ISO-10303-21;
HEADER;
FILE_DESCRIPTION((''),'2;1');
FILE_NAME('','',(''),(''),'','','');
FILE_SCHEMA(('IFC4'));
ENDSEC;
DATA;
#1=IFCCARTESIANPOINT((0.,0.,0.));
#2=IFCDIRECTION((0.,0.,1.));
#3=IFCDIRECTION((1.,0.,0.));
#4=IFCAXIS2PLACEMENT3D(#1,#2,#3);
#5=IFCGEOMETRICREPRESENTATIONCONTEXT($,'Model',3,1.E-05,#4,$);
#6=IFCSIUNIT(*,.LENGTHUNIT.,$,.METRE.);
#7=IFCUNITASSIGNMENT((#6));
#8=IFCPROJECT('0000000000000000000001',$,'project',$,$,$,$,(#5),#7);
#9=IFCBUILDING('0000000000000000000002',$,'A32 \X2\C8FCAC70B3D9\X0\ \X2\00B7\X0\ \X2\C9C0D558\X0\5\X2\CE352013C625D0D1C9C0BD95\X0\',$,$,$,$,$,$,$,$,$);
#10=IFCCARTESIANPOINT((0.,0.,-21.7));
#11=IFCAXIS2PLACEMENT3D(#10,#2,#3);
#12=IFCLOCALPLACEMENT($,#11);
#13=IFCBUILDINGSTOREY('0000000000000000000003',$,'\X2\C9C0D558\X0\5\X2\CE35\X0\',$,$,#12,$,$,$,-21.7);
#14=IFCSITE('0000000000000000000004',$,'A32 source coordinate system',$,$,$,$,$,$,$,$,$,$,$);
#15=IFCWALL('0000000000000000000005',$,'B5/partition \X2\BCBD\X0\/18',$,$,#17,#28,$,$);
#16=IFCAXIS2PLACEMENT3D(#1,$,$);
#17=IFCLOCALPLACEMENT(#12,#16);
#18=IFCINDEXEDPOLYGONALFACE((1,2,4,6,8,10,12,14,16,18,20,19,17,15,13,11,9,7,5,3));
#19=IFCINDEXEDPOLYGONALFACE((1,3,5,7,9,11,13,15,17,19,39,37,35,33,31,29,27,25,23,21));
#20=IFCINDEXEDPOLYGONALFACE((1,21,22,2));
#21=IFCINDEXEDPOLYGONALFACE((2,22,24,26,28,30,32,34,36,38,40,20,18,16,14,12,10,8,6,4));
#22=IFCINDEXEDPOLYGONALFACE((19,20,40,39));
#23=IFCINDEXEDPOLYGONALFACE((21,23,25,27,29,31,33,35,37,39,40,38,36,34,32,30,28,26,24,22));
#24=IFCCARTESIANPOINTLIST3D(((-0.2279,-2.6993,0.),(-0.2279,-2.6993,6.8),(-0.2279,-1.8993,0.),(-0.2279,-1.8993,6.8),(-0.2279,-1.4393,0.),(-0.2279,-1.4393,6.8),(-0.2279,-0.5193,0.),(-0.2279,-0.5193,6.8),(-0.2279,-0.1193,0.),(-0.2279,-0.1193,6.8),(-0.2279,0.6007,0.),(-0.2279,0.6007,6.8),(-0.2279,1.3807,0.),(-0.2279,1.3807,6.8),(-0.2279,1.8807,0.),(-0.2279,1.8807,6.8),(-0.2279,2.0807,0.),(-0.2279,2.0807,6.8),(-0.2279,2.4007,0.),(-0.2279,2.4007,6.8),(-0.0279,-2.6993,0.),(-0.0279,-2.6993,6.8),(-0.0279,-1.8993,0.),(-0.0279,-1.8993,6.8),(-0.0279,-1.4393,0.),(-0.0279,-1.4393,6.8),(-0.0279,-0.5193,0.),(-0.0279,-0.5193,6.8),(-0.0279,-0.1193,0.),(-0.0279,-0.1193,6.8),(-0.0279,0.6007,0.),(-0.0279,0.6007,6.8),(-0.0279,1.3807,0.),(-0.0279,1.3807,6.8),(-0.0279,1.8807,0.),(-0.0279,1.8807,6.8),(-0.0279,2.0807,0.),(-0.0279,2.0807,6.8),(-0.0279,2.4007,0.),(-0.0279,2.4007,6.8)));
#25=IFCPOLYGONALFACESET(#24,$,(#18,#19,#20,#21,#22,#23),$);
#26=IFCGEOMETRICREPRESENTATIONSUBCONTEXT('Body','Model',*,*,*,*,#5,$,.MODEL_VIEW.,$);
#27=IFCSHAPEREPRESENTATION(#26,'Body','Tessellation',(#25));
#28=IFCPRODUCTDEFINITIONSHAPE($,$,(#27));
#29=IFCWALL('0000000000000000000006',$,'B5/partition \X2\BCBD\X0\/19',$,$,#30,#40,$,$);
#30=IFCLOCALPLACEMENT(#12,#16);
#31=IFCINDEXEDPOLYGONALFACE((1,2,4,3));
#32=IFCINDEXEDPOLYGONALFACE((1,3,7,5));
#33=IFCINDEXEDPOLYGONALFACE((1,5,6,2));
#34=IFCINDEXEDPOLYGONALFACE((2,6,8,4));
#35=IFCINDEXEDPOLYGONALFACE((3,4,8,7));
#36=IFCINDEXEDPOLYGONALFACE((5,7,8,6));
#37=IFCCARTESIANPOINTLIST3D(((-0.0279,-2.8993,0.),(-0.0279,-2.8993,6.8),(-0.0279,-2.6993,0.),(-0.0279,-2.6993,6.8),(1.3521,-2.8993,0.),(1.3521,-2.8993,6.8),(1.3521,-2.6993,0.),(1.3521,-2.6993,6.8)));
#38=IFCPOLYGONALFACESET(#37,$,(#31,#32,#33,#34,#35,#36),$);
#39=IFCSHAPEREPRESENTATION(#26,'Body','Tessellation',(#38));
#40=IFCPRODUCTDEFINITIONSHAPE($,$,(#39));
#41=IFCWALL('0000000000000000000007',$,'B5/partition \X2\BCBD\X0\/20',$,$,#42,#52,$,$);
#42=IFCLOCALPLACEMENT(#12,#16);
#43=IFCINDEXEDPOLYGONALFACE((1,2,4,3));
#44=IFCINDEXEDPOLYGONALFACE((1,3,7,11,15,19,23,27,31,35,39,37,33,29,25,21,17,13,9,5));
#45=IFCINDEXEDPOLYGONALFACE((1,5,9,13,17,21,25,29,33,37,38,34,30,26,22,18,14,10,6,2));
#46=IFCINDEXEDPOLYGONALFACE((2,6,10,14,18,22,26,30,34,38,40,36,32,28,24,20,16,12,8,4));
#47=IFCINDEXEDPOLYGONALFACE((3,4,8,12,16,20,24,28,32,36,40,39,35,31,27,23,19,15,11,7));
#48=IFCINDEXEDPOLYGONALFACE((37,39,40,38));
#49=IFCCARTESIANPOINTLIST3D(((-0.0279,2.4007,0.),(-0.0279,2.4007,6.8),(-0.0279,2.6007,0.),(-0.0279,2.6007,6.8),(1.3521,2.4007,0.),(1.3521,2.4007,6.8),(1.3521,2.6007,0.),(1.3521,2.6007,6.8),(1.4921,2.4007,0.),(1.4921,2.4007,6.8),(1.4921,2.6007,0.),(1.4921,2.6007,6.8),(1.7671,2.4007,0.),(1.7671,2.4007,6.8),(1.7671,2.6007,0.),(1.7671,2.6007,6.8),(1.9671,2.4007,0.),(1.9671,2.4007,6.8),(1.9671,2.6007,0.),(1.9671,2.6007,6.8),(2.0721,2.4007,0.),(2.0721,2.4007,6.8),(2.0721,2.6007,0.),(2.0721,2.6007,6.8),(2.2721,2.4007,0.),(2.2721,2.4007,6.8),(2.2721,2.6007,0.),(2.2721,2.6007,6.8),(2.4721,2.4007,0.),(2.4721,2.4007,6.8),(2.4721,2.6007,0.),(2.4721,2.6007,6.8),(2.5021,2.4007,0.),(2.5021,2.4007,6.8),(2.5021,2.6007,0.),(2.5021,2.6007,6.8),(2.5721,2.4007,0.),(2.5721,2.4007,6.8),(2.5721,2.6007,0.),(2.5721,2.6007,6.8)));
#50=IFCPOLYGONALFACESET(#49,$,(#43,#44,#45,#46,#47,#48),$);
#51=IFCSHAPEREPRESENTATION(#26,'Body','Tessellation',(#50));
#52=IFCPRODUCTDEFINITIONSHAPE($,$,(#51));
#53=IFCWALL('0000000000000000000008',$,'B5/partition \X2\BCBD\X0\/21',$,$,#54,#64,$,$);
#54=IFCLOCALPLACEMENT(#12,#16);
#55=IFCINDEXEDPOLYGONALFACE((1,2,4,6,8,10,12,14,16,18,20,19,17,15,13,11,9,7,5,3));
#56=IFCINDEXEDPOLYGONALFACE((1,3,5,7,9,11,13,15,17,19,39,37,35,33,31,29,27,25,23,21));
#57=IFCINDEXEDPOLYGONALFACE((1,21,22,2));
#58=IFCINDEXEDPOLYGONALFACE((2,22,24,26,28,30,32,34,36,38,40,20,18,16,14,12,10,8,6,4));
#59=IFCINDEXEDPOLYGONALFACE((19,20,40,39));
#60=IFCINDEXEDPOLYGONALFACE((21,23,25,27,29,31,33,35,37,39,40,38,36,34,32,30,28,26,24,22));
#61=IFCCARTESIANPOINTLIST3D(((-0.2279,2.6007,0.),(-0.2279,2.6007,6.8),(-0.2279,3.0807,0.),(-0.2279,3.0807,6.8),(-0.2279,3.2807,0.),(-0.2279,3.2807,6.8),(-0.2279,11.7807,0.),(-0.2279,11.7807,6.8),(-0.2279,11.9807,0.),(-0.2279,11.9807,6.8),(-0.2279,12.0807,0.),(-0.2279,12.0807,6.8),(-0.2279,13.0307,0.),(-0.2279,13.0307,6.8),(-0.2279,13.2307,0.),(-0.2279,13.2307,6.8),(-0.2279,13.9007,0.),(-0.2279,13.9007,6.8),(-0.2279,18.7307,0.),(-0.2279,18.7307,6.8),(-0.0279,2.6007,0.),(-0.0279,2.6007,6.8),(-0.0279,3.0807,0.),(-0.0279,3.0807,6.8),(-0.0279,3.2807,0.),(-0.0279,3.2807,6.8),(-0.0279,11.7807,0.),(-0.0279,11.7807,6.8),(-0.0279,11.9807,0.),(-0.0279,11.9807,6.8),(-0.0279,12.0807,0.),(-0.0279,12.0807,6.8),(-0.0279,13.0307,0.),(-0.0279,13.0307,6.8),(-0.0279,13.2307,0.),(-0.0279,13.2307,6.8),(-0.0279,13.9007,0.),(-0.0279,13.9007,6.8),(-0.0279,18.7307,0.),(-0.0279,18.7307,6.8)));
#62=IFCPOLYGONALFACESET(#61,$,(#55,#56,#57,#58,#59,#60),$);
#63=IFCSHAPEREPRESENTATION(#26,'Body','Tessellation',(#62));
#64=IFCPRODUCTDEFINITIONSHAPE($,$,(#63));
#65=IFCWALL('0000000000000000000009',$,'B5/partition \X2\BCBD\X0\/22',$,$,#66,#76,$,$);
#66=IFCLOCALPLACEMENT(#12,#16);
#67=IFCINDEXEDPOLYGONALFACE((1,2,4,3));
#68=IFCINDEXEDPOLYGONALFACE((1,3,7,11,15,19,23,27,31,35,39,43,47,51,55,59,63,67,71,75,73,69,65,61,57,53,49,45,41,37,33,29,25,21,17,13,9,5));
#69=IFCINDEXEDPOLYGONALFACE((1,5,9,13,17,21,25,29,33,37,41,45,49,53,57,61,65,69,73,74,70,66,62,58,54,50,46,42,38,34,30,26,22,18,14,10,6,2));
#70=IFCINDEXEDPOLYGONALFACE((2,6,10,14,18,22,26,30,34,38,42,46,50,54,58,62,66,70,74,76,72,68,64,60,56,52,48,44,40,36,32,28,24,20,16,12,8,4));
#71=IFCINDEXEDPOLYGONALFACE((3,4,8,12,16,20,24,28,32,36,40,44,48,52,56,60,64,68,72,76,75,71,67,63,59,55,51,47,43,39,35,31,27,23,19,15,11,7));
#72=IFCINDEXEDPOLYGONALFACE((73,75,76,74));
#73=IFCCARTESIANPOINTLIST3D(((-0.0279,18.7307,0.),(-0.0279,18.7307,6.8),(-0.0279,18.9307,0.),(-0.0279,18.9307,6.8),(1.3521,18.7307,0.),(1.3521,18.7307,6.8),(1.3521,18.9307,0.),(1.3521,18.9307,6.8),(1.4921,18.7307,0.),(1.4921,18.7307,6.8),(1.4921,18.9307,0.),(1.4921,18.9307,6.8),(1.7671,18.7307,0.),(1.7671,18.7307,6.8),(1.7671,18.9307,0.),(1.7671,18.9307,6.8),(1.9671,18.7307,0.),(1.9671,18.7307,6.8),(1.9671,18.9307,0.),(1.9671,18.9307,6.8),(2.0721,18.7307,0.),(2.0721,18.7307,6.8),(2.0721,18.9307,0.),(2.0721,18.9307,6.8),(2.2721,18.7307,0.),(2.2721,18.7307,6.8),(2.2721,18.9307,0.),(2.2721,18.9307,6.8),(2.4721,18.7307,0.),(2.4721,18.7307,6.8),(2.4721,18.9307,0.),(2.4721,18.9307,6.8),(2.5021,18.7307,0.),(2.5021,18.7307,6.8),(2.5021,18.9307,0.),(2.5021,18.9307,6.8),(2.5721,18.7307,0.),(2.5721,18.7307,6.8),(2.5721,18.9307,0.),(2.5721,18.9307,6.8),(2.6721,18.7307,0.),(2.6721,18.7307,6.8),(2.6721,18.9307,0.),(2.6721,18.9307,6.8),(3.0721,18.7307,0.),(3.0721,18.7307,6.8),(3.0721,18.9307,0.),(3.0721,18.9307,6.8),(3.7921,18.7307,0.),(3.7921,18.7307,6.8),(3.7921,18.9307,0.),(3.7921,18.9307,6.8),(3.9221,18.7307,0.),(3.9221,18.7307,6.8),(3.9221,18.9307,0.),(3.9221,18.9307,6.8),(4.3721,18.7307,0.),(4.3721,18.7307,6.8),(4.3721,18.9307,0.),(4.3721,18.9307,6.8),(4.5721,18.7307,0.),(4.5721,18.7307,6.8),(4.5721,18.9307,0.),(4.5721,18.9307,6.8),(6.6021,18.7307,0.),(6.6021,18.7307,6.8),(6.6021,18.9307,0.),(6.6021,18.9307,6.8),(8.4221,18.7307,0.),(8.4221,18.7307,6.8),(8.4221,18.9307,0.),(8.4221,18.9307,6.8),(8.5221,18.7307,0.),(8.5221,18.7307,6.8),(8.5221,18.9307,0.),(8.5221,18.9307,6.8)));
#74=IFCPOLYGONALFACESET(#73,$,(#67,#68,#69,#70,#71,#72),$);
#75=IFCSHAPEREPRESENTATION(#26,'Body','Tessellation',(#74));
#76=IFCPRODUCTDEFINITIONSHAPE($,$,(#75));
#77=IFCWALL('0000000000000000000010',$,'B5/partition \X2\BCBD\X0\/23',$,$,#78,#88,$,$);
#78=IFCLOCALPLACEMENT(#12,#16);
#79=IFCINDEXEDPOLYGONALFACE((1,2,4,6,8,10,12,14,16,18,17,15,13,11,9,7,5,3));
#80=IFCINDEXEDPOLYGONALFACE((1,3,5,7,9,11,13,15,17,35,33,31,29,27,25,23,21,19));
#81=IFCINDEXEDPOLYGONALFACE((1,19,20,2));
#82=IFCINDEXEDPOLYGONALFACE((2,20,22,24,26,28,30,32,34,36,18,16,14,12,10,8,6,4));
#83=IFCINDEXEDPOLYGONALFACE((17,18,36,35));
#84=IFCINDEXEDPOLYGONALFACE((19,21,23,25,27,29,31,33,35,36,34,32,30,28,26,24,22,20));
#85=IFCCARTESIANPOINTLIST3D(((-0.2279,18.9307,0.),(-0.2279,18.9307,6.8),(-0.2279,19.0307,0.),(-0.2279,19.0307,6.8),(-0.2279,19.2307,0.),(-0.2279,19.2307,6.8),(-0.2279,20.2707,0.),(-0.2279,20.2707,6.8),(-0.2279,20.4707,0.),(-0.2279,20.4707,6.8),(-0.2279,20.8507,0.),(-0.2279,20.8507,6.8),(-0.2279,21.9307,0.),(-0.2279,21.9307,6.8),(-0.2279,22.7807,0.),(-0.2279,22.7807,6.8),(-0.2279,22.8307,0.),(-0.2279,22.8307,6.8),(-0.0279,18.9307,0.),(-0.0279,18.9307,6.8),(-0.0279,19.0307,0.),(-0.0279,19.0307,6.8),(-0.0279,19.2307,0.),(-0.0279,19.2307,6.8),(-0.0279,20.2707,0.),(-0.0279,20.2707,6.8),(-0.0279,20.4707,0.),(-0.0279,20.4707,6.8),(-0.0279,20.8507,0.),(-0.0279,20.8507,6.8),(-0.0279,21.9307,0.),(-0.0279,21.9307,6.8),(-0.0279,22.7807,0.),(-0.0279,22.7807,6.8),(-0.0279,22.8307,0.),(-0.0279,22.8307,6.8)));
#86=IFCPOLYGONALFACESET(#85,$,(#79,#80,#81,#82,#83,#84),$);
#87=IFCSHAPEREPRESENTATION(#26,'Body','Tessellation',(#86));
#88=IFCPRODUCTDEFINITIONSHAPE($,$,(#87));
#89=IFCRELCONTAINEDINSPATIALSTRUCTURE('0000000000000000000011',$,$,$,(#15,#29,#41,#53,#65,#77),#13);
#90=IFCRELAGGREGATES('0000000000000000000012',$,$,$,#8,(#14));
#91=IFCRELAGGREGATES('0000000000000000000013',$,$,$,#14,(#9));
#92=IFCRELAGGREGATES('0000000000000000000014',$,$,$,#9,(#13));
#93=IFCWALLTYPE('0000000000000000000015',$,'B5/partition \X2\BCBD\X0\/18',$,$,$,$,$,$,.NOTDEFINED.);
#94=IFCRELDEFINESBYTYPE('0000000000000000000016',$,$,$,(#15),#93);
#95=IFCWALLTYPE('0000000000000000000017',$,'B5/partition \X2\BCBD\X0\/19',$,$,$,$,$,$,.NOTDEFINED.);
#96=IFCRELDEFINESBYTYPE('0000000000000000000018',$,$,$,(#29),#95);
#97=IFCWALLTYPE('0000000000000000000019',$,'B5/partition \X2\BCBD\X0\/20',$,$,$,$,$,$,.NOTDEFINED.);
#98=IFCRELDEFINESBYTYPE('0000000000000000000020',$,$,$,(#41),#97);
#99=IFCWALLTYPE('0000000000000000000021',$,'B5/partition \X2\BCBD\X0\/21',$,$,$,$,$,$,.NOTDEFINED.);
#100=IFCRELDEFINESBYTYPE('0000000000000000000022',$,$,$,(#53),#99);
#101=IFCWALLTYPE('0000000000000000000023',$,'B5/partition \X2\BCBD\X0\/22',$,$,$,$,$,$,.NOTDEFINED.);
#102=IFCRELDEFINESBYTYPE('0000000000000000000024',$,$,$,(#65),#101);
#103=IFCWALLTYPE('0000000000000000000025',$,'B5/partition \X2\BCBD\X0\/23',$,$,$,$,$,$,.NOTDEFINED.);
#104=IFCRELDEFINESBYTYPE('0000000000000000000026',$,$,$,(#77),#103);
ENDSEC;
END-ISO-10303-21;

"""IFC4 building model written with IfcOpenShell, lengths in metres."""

from ifc_helpers import new_model, si_unit, frame, origin, origin_with_axes, place, context, subcontext, project, spatial, polyline, outline, extrude, source, transform, mapped, type_object, type_shapes, element, save


model = new_model("IFC4")

# Units and contexts
model_context = context("Model", 3, precision=1e-05, world=origin_with_axes())
body_context = subcontext(model_context, "Body", "Model", "MODEL_VIEW")
ifc_project = project(units=[si_unit("LENGTHUNIT", "METRE")], contexts=[model_context])

# Site, building, storey
site = spatial("IfcSite", under=ifc_project, Name="A32 source coordinate system")
building = spatial("IfcBuilding", under=site, Name="A32 주거동 · 지하5층–옥탑지붕")
storey_placement = place(None, frame((0.0, 0.0, -21.7), z_axis=(0.0, 0.0, 1.0), x_axis=(1.0, 0.0, 0.0)))
storey = spatial("IfcBuildingStorey", under=building, at=storey_placement, Name="지하5층", Elevation=-21.7)

# Walls
wall_type_1 = type_object("IfcWallType", Name="B5/partition 벽/18", PredefinedType="NOTDEFINED")
shared_shape_1 = source(origin(), body_context, "Body", "SweptSolid", [
    extrude(outline(polyline([(-0.2279, 1.8807), (-0.2279, 2.0807), (-0.2279, 2.4007), (-0.0279, 2.4007), (-0.0279, 2.0807), (-0.0279, 1.8807), (-0.0279, 1.3807), (-0.0279, 0.6007), (-0.0279, -0.1193), (-0.0279, -0.5193), (-0.0279, -1.4393), (-0.0279, -1.8993), (-0.0279, -2.6993), (-0.2279, -2.6993), (-0.2279, -1.8993), (-0.2279, -1.4393), (-0.2279, -0.5193), (-0.2279, -0.1193), (-0.2279, 0.6007), (-0.2279, 1.3807), (-0.2279, 1.8807)])), origin(), (0.0, 0.0, 1.0), 6.8),
])
type_shapes(wall_type_1, [shared_shape_1])
wall_1_placement = place(storey_placement, origin_with_axes())
element("IfcWall", 1, at=wall_1_placement, inside=storey, type_object=wall_type_1, Name="B5/partition 벽/18", context=body_context, shape_type="MappedRepresentation", body=[
    mapped(shared_shape_1, transform((0.0, 0.0, 0.0), scale=1.0)),
])
wall_type_2 = type_object("IfcWallType", Name="B5/partition 벽/19", PredefinedType="NOTDEFINED")
shared_shape_2 = source(origin(), body_context, "Body", "SweptSolid", [
    extrude(outline(polyline([(1.3521, -2.6993), (1.3521, -2.8993), (-0.0279, -2.8993), (-0.0279, -2.6993), (1.3521, -2.6993)])), origin(), (0.0, 0.0, 1.0), 6.8),
])
type_shapes(wall_type_2, [shared_shape_2])
wall_2_placement = place(storey_placement, origin_with_axes())
element("IfcWall", 2, at=wall_2_placement, inside=storey, type_object=wall_type_2, Name="B5/partition 벽/19", context=body_context, shape_type="MappedRepresentation", body=[
    mapped(shared_shape_2, transform((0.0, 0.0, 0.0), scale=1.0)),
])
wall_type_3 = type_object("IfcWallType", Name="B5/partition 벽/20", PredefinedType="NOTDEFINED")
shared_shape_3 = source(origin(), body_context, "Body", "SweptSolid", [
    extrude(outline(polyline([(-0.0279, 2.6007), (1.3521, 2.6007), (1.4921, 2.6007), (1.7671, 2.6007), (1.9671, 2.6007), (2.0721, 2.6007), (2.2721, 2.6007), (2.4721, 2.6007), (2.5021, 2.6007), (2.5721, 2.6007), (2.5721, 2.4007), (2.5021, 2.4007), (2.4721, 2.4007), (2.2721, 2.4007), (2.0721, 2.4007), (1.9671, 2.4007), (1.7671, 2.4007), (1.4921, 2.4007), (1.3521, 2.4007), (-0.0279, 2.4007), (-0.0279, 2.6007)])), origin(), (0.0, 0.0, 1.0), 6.8),
])
type_shapes(wall_type_3, [shared_shape_3])
wall_3_placement = place(storey_placement, origin_with_axes())
element("IfcWall", 3, at=wall_3_placement, inside=storey, type_object=wall_type_3, Name="B5/partition 벽/20", context=body_context, shape_type="MappedRepresentation", body=[
    mapped(shared_shape_3, transform((0.0, 0.0, 0.0), scale=1.0)),
])
wall_type_4 = type_object("IfcWallType", Name="B5/partition 벽/21", PredefinedType="NOTDEFINED")
shared_shape_4 = source(origin(), body_context, "Body", "SweptSolid", [
    extrude(outline(polyline([(-0.2279, 2.6007), (-0.2279, 3.0807), (-0.2279, 3.2807), (-0.2279, 11.7807), (-0.2279, 11.9807), (-0.2279, 12.0807), (-0.2279, 13.0307), (-0.2279, 13.2307), (-0.2279, 13.9007), (-0.2279, 18.7307), (-0.0279, 18.7307), (-0.0279, 13.9007), (-0.0279, 13.2307), (-0.0279, 13.0307), (-0.0279, 12.0807), (-0.0279, 11.9807), (-0.0279, 11.7807), (-0.0279, 3.2807), (-0.0279, 3.0807), (-0.0279, 2.6007), (-0.2279, 2.6007)])), origin(), (0.0, 0.0, 1.0), 6.8),
])
type_shapes(wall_type_4, [shared_shape_4])
wall_4_placement = place(storey_placement, origin_with_axes())
element("IfcWall", 4, at=wall_4_placement, inside=storey, type_object=wall_type_4, Name="B5/partition 벽/21", context=body_context, shape_type="MappedRepresentation", body=[
    mapped(shared_shape_4, transform((0.0, 0.0, 0.0), scale=1.0)),
])
wall_type_5 = type_object("IfcWallType", Name="B5/partition 벽/22", PredefinedType="NOTDEFINED")
shared_shape_5 = source(origin(), body_context, "Body", "SweptSolid", [
    extrude(outline(polyline([(-0.0279, 18.9307), (1.3521, 18.9307), (1.4921, 18.9307), (1.7671, 18.9307), (1.9671, 18.9307), (2.0721, 18.9307), (2.2721, 18.9307), (2.4721, 18.9307), (2.5021, 18.9307), (2.5721, 18.9307), (2.6721, 18.9307), (3.0721, 18.9307), (3.7921, 18.9307), (3.9221, 18.9307), (4.3721, 18.9307), (4.5721, 18.9307), (6.6021, 18.9307), (8.4221, 18.9307), (8.5221, 18.9307), (8.5221, 18.7307), (8.4221, 18.7307), (6.6021, 18.7307), (4.5721, 18.7307), (4.3721, 18.7307), (3.9221, 18.7307), (3.7921, 18.7307), (3.0721, 18.7307), (2.6721, 18.7307), (2.5721, 18.7307), (2.5021, 18.7307), (2.4721, 18.7307), (2.2721, 18.7307), (2.0721, 18.7307), (1.9671, 18.7307), (1.7671, 18.7307), (1.4921, 18.7307), (1.3521, 18.7307), (-0.0279, 18.7307), (-0.0279, 18.9307)])), origin(), (0.0, 0.0, 1.0), 6.8),
])
type_shapes(wall_type_5, [shared_shape_5])
wall_5_placement = place(storey_placement, origin_with_axes())
element("IfcWall", 5, at=wall_5_placement, inside=storey, type_object=wall_type_5, Name="B5/partition 벽/22", context=body_context, shape_type="MappedRepresentation", body=[
    mapped(shared_shape_5, transform((0.0, 0.0, 0.0), scale=1.0)),
])
wall_type_6 = type_object("IfcWallType", Name="B5/partition 벽/23", PredefinedType="NOTDEFINED")
shared_shape_6 = source(origin(), body_context, "Body", "SweptSolid", [
    extrude(outline(polyline([(-0.2279, 18.9307), (-0.2279, 19.0307), (-0.2279, 19.2307), (-0.2279, 20.2707), (-0.2279, 20.4707), (-0.2279, 20.8507), (-0.2279, 21.9307), (-0.2279, 22.7807), (-0.2279, 22.8307), (-0.0279, 22.8307), (-0.0279, 22.7807), (-0.0279, 21.9307), (-0.0279, 20.8507), (-0.0279, 20.4707), (-0.0279, 20.2707), (-0.0279, 19.2307), (-0.0279, 19.0307), (-0.0279, 18.9307), (-0.2279, 18.9307)])), origin(), (0.0, 0.0, 1.0), 6.8),
])
type_shapes(wall_type_6, [shared_shape_6])
wall_6_placement = place(storey_placement, origin_with_axes())
element("IfcWall", 6, at=wall_6_placement, inside=storey, type_object=wall_type_6, Name="B5/partition 벽/23", context=body_context, shape_type="MappedRepresentation", body=[
    mapped(shared_shape_6, transform((0.0, 0.0, 0.0), scale=1.0)),
])

save(model, "model.ifc")
